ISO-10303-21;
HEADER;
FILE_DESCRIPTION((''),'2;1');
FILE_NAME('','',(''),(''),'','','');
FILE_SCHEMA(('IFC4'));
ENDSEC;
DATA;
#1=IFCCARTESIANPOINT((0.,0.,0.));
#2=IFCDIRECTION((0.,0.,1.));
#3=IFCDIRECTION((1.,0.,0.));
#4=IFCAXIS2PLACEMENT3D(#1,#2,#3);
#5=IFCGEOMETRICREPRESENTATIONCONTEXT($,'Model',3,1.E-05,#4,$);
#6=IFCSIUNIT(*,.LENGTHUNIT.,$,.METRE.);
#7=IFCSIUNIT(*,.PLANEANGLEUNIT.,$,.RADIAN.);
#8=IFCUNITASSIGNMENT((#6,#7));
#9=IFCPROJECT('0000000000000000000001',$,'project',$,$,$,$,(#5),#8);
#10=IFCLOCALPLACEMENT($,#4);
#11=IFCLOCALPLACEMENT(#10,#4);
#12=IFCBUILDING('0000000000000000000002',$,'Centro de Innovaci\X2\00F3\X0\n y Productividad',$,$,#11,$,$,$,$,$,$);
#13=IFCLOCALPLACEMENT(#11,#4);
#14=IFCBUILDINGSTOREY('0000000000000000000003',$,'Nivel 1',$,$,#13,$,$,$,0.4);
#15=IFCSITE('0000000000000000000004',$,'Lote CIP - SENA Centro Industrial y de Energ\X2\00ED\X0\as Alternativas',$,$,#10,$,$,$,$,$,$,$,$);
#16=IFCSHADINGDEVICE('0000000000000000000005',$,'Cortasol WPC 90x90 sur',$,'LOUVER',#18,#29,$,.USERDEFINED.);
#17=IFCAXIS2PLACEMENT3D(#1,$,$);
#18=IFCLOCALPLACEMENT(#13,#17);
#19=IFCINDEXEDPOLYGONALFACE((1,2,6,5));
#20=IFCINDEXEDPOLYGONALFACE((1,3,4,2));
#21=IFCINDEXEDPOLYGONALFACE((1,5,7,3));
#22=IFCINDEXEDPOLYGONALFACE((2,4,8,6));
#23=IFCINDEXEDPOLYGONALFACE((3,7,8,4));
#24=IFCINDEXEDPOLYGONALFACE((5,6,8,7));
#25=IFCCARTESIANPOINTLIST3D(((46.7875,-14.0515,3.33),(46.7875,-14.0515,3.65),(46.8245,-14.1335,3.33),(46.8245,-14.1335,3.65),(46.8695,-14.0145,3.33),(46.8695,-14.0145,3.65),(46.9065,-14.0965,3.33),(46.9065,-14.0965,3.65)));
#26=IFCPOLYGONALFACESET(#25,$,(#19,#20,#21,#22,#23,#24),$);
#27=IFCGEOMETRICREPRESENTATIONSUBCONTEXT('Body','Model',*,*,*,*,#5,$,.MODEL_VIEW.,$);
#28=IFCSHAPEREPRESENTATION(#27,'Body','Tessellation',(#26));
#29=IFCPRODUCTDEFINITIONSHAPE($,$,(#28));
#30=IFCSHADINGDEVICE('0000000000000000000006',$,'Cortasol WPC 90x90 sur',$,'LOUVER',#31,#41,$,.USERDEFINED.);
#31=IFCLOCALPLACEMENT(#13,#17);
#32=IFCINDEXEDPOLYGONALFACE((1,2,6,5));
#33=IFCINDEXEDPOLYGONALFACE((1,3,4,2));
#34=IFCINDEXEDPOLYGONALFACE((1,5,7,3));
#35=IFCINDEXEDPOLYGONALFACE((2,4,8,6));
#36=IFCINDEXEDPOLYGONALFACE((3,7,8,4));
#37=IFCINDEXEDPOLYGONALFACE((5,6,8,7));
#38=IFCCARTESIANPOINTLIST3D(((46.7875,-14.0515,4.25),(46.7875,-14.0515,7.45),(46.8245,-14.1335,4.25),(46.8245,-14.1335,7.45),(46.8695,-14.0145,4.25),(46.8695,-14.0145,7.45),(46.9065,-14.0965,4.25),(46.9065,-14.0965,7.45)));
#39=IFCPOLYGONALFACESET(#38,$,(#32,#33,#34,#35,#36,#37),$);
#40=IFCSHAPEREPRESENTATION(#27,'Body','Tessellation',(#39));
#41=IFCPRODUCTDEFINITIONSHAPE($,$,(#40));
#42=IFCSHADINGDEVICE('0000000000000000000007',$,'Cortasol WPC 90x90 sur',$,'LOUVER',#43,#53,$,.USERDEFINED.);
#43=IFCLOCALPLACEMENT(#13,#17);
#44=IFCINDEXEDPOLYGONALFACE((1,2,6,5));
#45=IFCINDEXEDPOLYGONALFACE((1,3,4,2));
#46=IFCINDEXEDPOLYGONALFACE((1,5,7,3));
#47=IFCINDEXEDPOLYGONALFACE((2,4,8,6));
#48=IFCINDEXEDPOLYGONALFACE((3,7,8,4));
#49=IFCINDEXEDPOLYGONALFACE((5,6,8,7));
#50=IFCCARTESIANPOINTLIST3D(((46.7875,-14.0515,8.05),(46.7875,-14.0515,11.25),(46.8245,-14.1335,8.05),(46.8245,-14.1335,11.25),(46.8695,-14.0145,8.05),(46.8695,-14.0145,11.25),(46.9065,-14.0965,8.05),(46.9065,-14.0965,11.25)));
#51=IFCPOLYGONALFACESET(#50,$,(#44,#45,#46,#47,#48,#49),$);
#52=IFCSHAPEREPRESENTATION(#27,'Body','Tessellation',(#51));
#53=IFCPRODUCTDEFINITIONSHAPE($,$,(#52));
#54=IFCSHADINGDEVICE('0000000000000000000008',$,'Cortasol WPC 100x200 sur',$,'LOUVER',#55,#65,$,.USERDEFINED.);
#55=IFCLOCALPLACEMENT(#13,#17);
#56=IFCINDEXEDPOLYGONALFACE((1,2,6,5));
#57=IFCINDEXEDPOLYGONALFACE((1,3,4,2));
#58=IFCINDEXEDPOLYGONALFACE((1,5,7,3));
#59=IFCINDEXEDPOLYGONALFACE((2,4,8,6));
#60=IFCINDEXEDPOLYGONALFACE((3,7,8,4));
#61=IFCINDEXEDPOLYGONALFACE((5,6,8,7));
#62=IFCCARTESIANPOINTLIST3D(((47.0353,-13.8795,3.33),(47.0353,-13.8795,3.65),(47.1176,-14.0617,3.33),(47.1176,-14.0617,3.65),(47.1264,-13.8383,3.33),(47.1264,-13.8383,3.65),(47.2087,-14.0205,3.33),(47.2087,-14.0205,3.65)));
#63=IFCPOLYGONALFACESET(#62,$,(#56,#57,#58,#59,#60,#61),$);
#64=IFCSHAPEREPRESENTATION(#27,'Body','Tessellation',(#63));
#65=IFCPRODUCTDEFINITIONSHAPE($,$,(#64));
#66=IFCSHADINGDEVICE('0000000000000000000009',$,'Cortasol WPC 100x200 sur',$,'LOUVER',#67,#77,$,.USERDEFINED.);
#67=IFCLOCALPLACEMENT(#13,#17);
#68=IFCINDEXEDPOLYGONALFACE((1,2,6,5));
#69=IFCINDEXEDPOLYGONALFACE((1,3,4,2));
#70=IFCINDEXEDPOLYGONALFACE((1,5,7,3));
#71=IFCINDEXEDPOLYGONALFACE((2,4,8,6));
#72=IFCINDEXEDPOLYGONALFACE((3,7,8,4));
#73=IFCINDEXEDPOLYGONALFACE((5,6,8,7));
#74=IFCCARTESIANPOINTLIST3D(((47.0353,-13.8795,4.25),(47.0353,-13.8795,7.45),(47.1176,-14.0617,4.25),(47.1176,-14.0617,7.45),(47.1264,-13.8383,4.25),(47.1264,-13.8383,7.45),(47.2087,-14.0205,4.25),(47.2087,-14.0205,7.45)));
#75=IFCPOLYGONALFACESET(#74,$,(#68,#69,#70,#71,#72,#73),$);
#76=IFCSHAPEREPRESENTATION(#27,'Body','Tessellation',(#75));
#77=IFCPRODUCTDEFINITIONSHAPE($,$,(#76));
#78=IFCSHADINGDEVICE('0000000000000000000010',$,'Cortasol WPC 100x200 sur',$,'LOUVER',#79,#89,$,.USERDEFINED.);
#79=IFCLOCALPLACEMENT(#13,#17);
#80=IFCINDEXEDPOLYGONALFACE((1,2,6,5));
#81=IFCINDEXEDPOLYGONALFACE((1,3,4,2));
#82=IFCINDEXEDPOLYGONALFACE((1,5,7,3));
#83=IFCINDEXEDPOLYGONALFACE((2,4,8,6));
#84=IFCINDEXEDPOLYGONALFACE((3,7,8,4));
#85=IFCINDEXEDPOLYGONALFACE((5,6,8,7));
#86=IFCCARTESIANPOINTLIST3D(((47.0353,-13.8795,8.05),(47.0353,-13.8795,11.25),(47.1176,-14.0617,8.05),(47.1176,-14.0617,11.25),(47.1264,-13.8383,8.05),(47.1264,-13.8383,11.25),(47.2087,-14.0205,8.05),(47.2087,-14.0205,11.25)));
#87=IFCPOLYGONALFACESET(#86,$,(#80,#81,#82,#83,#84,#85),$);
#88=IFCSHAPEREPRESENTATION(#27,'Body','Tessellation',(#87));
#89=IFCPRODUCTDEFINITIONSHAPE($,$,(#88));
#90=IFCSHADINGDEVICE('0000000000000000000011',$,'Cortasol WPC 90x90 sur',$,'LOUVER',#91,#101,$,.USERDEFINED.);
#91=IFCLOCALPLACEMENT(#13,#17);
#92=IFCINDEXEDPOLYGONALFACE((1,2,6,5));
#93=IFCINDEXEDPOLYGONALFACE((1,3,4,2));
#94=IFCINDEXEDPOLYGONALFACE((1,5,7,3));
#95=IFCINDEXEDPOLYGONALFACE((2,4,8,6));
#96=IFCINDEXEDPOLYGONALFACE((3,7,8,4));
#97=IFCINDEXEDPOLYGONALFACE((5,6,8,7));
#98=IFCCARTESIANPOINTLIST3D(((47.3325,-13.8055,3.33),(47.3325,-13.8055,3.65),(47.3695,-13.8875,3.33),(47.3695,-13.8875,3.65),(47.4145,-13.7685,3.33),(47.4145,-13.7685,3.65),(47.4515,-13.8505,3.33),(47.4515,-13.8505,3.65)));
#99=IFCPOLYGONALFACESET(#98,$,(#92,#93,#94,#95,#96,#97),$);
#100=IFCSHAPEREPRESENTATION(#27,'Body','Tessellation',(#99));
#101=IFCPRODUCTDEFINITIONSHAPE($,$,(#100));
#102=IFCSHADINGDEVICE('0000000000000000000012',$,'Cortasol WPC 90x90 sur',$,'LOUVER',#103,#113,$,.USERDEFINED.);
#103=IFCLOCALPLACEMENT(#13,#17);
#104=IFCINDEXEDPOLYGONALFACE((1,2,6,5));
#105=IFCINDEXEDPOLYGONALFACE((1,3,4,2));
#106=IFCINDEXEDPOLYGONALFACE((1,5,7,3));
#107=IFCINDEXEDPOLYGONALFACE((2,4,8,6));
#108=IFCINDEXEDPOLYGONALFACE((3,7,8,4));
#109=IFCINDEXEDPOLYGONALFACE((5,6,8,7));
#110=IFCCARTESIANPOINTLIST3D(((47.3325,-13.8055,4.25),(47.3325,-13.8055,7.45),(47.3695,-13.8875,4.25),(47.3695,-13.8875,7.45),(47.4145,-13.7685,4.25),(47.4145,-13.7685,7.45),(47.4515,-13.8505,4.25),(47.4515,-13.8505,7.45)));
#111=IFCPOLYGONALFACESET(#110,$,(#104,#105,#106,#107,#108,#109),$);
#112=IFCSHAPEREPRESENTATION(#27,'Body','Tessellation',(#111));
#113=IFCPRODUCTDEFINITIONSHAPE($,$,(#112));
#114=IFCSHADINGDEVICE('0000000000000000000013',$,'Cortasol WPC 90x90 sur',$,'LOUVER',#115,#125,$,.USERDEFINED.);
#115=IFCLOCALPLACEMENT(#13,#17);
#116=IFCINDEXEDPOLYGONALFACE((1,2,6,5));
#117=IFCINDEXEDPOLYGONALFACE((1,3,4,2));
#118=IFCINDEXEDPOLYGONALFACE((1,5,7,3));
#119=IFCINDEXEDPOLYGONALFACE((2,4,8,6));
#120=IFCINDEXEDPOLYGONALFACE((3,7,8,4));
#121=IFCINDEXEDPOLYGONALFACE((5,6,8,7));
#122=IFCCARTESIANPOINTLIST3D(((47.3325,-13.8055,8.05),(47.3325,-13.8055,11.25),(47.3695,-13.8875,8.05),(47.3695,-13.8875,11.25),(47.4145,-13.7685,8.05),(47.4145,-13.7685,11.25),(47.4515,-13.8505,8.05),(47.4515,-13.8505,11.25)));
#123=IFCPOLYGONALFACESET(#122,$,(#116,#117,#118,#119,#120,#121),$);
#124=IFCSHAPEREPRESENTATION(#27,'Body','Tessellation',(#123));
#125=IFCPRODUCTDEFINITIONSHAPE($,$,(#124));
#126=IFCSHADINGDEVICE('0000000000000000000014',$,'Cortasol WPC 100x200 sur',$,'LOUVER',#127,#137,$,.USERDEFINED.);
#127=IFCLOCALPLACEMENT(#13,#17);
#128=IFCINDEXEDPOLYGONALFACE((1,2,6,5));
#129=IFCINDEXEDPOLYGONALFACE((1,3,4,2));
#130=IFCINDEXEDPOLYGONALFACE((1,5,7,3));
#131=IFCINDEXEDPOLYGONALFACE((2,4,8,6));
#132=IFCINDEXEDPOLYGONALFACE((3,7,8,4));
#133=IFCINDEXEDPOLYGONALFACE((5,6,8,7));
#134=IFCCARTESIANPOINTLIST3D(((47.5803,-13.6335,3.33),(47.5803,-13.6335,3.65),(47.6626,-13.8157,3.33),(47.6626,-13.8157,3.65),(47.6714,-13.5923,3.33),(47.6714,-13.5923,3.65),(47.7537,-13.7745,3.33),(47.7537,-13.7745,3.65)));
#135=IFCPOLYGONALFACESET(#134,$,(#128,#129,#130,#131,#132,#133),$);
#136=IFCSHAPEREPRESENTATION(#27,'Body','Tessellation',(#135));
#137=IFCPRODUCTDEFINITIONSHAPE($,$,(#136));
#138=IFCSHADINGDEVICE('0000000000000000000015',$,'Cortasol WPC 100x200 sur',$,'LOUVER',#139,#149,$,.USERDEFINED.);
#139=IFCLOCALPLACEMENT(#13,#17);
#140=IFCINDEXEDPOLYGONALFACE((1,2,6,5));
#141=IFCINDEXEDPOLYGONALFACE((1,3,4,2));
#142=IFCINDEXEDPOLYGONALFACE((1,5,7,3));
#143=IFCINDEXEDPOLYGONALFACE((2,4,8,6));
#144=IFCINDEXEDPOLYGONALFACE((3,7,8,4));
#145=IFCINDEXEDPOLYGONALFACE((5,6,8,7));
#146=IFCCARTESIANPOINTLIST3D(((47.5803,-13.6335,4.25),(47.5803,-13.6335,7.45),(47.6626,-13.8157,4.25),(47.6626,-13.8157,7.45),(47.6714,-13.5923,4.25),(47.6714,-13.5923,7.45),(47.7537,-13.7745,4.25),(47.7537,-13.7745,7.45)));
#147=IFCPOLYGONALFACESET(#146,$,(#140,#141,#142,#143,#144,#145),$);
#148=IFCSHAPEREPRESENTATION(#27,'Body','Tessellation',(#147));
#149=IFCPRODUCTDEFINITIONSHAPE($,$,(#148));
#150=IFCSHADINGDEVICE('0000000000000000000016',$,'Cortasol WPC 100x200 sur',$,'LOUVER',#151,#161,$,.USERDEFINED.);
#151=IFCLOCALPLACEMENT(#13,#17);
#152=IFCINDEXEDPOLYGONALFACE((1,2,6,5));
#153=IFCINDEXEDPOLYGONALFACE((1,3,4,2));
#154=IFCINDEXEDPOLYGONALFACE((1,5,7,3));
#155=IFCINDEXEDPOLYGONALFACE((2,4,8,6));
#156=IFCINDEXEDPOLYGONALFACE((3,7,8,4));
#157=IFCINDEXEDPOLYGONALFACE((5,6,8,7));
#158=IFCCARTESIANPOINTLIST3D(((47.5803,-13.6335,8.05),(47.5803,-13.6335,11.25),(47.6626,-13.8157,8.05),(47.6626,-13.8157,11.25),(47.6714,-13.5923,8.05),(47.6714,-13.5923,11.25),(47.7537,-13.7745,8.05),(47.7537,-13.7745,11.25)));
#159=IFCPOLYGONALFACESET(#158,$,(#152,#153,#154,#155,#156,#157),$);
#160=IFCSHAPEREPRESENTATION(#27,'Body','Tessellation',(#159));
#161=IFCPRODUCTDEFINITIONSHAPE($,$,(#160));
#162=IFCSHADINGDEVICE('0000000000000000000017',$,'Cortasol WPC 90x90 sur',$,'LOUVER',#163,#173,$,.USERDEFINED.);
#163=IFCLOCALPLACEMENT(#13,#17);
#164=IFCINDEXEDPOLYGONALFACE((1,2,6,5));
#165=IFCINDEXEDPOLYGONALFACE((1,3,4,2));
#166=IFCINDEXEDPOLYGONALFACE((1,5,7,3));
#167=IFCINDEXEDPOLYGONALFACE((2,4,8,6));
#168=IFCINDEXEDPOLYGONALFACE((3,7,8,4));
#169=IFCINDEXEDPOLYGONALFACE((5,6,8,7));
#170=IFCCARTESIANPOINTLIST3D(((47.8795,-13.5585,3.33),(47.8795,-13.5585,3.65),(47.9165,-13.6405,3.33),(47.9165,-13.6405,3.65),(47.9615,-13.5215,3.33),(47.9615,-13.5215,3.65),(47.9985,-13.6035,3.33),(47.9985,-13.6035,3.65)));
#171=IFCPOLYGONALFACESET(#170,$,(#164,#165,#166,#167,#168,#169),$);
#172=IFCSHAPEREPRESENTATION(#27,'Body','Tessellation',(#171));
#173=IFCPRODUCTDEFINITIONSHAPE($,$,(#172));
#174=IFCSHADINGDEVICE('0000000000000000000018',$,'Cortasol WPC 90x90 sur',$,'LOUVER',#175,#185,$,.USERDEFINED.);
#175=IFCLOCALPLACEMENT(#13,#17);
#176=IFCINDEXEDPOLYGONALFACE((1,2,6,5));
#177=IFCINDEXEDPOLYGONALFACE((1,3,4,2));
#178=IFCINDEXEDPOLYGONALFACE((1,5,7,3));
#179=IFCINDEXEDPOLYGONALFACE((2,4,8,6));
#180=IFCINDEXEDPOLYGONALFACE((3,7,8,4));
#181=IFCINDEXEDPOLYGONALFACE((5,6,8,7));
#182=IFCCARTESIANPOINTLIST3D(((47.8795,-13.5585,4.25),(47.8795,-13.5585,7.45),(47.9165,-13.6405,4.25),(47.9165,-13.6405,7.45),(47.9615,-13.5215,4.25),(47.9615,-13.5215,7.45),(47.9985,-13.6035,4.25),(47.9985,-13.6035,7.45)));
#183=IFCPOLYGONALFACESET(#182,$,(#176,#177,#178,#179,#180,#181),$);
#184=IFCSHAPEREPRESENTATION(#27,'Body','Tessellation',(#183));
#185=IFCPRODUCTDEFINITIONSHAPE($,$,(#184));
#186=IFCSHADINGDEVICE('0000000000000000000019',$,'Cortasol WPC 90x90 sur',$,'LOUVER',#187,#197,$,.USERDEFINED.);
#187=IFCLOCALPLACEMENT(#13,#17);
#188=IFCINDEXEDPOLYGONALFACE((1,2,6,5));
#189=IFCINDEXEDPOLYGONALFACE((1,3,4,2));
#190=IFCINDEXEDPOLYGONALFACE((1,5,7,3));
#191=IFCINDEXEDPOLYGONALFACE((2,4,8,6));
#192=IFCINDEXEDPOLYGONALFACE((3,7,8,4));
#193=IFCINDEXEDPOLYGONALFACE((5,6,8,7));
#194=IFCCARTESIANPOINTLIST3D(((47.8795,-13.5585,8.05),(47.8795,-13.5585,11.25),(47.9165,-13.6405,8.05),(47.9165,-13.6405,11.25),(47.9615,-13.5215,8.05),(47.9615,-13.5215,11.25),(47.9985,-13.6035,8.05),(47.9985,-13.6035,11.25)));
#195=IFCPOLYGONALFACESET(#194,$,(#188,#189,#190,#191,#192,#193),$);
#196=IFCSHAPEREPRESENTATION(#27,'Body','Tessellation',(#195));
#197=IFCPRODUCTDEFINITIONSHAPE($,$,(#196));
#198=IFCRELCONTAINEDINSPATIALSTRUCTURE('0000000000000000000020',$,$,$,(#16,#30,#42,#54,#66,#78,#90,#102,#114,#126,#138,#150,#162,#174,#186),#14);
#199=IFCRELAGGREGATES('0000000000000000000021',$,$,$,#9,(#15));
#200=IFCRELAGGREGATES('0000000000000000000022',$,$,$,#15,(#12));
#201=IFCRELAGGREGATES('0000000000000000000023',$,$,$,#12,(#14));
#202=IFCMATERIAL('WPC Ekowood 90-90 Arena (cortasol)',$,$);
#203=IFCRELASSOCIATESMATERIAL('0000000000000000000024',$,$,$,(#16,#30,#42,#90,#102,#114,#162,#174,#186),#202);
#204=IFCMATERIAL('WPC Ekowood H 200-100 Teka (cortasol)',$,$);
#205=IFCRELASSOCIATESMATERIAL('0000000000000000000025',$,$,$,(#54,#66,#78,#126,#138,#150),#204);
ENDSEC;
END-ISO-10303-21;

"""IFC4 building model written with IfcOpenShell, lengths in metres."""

from ifc_helpers import new_model, si_unit, frame, origin_with_axes, place, context, subcontext, project, spatial, polyline, outline, extrude, material, element, save


model = new_model("IFC4")

# Units and contexts
model_context = context("Model", 3, precision=1e-05, world=origin_with_axes())
body_context = subcontext(model_context, "Body", "Model", "MODEL_VIEW")
ifc_project = project(units=[si_unit("LENGTHUNIT", "METRE"), si_unit("PLANEANGLEUNIT", "RADIAN")], contexts=[model_context])

# Site, building, storey
site_placement = place(None, origin_with_axes())
site = spatial("IfcSite", under=ifc_project, at=site_placement, Name="Lote CIP - SENA Centro Industrial y de Energías Alternativas")
building_placement = place(site_placement, origin_with_axes())
building = spatial("IfcBuilding", under=site, at=building_placement, Name="Centro de Innovación y Productividad")
storey_placement = place(building_placement, origin_with_axes())
storey = spatial("IfcBuildingStorey", under=building, at=storey_placement, Name="Nivel 1", Elevation=0.4)

# Shading devices
ifc_material_1 = material(Name="WPC Ekowood 90-90 Arena (cortasol)")
shading_device_1_placement = place(storey_placement, origin_with_axes())
element("IfcShadingDevice", 1, at=shading_device_1_placement, inside=storey, material=ifc_material_1, Name="Cortasol WPC 90x90 sur", ObjectType="LOUVER", PredefinedType="USERDEFINED", context=body_context, shape_type="SweptSolid", body=[
    extrude(outline(polyline([(46.8245, -14.1335), (46.7875, -14.0515), (46.8695, -14.0145), (46.9065, -14.0965), (46.8245, -14.1335)])), frame((0.0, 0.0, 3.33)), (0.0, 0.0, 1.0), 0.32),
])
shading_device_2_placement = place(storey_placement, origin_with_axes())
element("IfcShadingDevice", 2, at=shading_device_2_placement, inside=storey, material=ifc_material_1, Name="Cortasol WPC 90x90 sur", ObjectType="LOUVER", PredefinedType="USERDEFINED", context=body_context, shape_type="SweptSolid", body=[
    extrude(outline(polyline([(46.8245, -14.1335), (46.7875, -14.0515), (46.8695, -14.0145), (46.9065, -14.0965), (46.8245, -14.1335)])), frame((0.0, 0.0, 4.25)), (0.0, 0.0, 1.0), 3.2),
])
shading_device_3_placement = place(storey_placement, origin_with_axes())
element("IfcShadingDevice", 3, at=shading_device_3_placement, inside=storey, material=ifc_material_1, Name="Cortasol WPC 90x90 sur", ObjectType="LOUVER", PredefinedType="USERDEFINED", context=body_context, shape_type="SweptSolid", body=[
    extrude(outline(polyline([(46.8245, -14.1335), (46.7875, -14.0515), (46.8695, -14.0145), (46.9065, -14.0965), (46.8245, -14.1335)])), frame((0.0, 0.0, 8.05)), (0.0, 0.0, 1.0), 3.2),
])
ifc_material_2 = material(Name="WPC Ekowood H 200-100 Teka (cortasol)")
shading_device_4_placement = place(storey_placement, origin_with_axes())
element("IfcShadingDevice", 4, at=shading_device_4_placement, inside=storey, material=ifc_material_2, Name="Cortasol WPC 100x200 sur", ObjectType="LOUVER", PredefinedType="USERDEFINED", context=body_context, shape_type="SweptSolid", body=[
    extrude(outline(polyline([(47.1176, -14.0617), (47.0353, -13.8795), (47.1264, -13.8383), (47.2087, -14.0205), (47.1176, -14.0617)])), frame((0.0, 0.0, 3.33)), (0.0, 0.0, 1.0), 0.32),
])
shading_device_5_placement = place(storey_placement, origin_with_axes())
element("IfcShadingDevice", 5, at=shading_device_5_placement, inside=storey, material=ifc_material_2, Name="Cortasol WPC 100x200 sur", ObjectType="LOUVER", PredefinedType="USERDEFINED", context=body_context, shape_type="SweptSolid", body=[
    extrude(outline(polyline([(47.1176, -14.0617), (47.0353, -13.8795), (47.1264, -13.8383), (47.2087, -14.0205), (47.1176, -14.0617)])), frame((0.0, 0.0, 4.25)), (0.0, 0.0, 1.0), 3.2),
])
shading_device_6_placement = place(storey_placement, origin_with_axes())
element("IfcShadingDevice", 6, at=shading_device_6_placement, inside=storey, material=ifc_material_2, Name="Cortasol WPC 100x200 sur", ObjectType="LOUVER", PredefinedType="USERDEFINED", context=body_context, shape_type="SweptSolid", body=[
    extrude(outline(polyline([(47.1176, -14.0617), (47.0353, -13.8795), (47.1264, -13.8383), (47.2087, -14.0205), (47.1176, -14.0617)])), frame((0.0, 0.0, 8.05)), (0.0, 0.0, 1.0), 3.2),
])
shading_device_7_placement = place(storey_placement, origin_with_axes())
element("IfcShadingDevice", 7, at=shading_device_7_placement, inside=storey, material=ifc_material_1, Name="Cortasol WPC 90x90 sur", ObjectType="LOUVER", PredefinedType="USERDEFINED", context=body_context, shape_type="SweptSolid", body=[
    extrude(outline(polyline([(47.3695, -13.8875), (47.3325, -13.8055), (47.4145, -13.7685), (47.4515, -13.8505), (47.3695, -13.8875)])), frame((0.0, 0.0, 3.33)), (0.0, 0.0, 1.0), 0.32),
])
shading_device_8_placement = place(storey_placement, origin_with_axes())
element("IfcShadingDevice", 8, at=shading_device_8_placement, inside=storey, material=ifc_material_1, Name="Cortasol WPC 90x90 sur", ObjectType="LOUVER", PredefinedType="USERDEFINED", context=body_context, shape_type="SweptSolid", body=[
    extrude(outline(polyline([(47.3695, -13.8875), (47.3325, -13.8055), (47.4145, -13.7685), (47.4515, -13.8505), (47.3695, -13.8875)])), frame((0.0, 0.0, 4.25)), (0.0, 0.0, 1.0), 3.2),
])
shading_device_9_placement = place(storey_placement, origin_with_axes())
element("IfcShadingDevice", 9, at=shading_device_9_placement, inside=storey, material=ifc_material_1, Name="Cortasol WPC 90x90 sur", ObjectType="LOUVER", PredefinedType="USERDEFINED", context=body_context, shape_type="SweptSolid", body=[
    extrude(outline(polyline([(47.3695, -13.8875), (47.3325, -13.8055), (47.4145, -13.7685), (47.4515, -13.8505), (47.3695, -13.8875)])), frame((0.0, 0.0, 8.05)), (0.0, 0.0, 1.0), 3.2),
])
shading_device_10_placement = place(storey_placement, origin_with_axes())
element("IfcShadingDevice", 10, at=shading_device_10_placement, inside=storey, material=ifc_material_2, Name="Cortasol WPC 100x200 sur", ObjectType="LOUVER", PredefinedType="USERDEFINED", context=body_context, shape_type="SweptSolid", body=[
    extrude(outline(polyline([(47.6626, -13.8157), (47.5803, -13.6335), (47.6714, -13.5923), (47.7537, -13.7745), (47.6626, -13.8157)])), frame((0.0, 0.0, 3.33)), (0.0, 0.0, 1.0), 0.32),
])
shading_device_11_placement = place(storey_placement, origin_with_axes())
element("IfcShadingDevice", 11, at=shading_device_11_placement, inside=storey, material=ifc_material_2, Name="Cortasol WPC 100x200 sur", ObjectType="LOUVER", PredefinedType="USERDEFINED", context=body_context, shape_type="SweptSolid", body=[
    extrude(outline(polyline([(47.6626, -13.8157), (47.5803, -13.6335), (47.6714, -13.5923), (47.7537, -13.7745), (47.6626, -13.8157)])), frame((0.0, 0.0, 4.25)), (0.0, 0.0, 1.0), 3.2),
])
shading_device_12_placement = place(storey_placement, origin_with_axes())
element("IfcShadingDevice", 12, at=shading_device_12_placement, inside=storey, material=ifc_material_2, Name="Cortasol WPC 100x200 sur", ObjectType="LOUVER", PredefinedType="USERDEFINED", context=body_context, shape_type="SweptSolid", body=[
    extrude(outline(polyline([(47.6626, -13.8157), (47.5803, -13.6335), (47.6714, -13.5923), (47.7537, -13.7745), (47.6626, -13.8157)])), frame((0.0, 0.0, 8.05)), (0.0, 0.0, 1.0), 3.2),
])
shading_device_13_placement = place(storey_placement, origin_with_axes())
element("IfcShadingDevice", 13, at=shading_device_13_placement, inside=storey, material=ifc_material_1, Name="Cortasol WPC 90x90 sur", ObjectType="LOUVER", PredefinedType="USERDEFINED", context=body_context, shape_type="SweptSolid", body=[
    extrude(outline(polyline([(47.9165, -13.6405), (47.8795, -13.5585), (47.9615, -13.5215), (47.9985, -13.6035), (47.9165, -13.6405)])), frame((0.0, 0.0, 3.33)), (0.0, 0.0, 1.0), 0.32),
])
shading_device_14_placement = place(storey_placement, origin_with_axes())
element("IfcShadingDevice", 14, at=shading_device_14_placement, inside=storey, material=ifc_material_1, Name="Cortasol WPC 90x90 sur", ObjectType="LOUVER", PredefinedType="USERDEFINED", context=body_context, shape_type="SweptSolid", body=[
    extrude(outline(polyline([(47.9165, -13.6405), (47.8795, -13.5585), (47.9615, -13.5215), (47.9985, -13.6035), (47.9165, -13.6405)])), frame((0.0, 0.0, 4.25)), (0.0, 0.0, 1.0), 3.2),
])
shading_device_15_placement = place(storey_placement, origin_with_axes())
element("IfcShadingDevice", 15, at=shading_device_15_placement, inside=storey, material=ifc_material_1, Name="Cortasol WPC 90x90 sur", ObjectType="LOUVER", PredefinedType="USERDEFINED", context=body_context, shape_type="SweptSolid", body=[
    extrude(outline(polyline([(47.9165, -13.6405), (47.8795, -13.5585), (47.9615, -13.5215), (47.9985, -13.6035), (47.9165, -13.6405)])), frame((0.0, 0.0, 8.05)), (0.0, 0.0, 1.0), 3.2),
])

save(model, "model.ifc")
